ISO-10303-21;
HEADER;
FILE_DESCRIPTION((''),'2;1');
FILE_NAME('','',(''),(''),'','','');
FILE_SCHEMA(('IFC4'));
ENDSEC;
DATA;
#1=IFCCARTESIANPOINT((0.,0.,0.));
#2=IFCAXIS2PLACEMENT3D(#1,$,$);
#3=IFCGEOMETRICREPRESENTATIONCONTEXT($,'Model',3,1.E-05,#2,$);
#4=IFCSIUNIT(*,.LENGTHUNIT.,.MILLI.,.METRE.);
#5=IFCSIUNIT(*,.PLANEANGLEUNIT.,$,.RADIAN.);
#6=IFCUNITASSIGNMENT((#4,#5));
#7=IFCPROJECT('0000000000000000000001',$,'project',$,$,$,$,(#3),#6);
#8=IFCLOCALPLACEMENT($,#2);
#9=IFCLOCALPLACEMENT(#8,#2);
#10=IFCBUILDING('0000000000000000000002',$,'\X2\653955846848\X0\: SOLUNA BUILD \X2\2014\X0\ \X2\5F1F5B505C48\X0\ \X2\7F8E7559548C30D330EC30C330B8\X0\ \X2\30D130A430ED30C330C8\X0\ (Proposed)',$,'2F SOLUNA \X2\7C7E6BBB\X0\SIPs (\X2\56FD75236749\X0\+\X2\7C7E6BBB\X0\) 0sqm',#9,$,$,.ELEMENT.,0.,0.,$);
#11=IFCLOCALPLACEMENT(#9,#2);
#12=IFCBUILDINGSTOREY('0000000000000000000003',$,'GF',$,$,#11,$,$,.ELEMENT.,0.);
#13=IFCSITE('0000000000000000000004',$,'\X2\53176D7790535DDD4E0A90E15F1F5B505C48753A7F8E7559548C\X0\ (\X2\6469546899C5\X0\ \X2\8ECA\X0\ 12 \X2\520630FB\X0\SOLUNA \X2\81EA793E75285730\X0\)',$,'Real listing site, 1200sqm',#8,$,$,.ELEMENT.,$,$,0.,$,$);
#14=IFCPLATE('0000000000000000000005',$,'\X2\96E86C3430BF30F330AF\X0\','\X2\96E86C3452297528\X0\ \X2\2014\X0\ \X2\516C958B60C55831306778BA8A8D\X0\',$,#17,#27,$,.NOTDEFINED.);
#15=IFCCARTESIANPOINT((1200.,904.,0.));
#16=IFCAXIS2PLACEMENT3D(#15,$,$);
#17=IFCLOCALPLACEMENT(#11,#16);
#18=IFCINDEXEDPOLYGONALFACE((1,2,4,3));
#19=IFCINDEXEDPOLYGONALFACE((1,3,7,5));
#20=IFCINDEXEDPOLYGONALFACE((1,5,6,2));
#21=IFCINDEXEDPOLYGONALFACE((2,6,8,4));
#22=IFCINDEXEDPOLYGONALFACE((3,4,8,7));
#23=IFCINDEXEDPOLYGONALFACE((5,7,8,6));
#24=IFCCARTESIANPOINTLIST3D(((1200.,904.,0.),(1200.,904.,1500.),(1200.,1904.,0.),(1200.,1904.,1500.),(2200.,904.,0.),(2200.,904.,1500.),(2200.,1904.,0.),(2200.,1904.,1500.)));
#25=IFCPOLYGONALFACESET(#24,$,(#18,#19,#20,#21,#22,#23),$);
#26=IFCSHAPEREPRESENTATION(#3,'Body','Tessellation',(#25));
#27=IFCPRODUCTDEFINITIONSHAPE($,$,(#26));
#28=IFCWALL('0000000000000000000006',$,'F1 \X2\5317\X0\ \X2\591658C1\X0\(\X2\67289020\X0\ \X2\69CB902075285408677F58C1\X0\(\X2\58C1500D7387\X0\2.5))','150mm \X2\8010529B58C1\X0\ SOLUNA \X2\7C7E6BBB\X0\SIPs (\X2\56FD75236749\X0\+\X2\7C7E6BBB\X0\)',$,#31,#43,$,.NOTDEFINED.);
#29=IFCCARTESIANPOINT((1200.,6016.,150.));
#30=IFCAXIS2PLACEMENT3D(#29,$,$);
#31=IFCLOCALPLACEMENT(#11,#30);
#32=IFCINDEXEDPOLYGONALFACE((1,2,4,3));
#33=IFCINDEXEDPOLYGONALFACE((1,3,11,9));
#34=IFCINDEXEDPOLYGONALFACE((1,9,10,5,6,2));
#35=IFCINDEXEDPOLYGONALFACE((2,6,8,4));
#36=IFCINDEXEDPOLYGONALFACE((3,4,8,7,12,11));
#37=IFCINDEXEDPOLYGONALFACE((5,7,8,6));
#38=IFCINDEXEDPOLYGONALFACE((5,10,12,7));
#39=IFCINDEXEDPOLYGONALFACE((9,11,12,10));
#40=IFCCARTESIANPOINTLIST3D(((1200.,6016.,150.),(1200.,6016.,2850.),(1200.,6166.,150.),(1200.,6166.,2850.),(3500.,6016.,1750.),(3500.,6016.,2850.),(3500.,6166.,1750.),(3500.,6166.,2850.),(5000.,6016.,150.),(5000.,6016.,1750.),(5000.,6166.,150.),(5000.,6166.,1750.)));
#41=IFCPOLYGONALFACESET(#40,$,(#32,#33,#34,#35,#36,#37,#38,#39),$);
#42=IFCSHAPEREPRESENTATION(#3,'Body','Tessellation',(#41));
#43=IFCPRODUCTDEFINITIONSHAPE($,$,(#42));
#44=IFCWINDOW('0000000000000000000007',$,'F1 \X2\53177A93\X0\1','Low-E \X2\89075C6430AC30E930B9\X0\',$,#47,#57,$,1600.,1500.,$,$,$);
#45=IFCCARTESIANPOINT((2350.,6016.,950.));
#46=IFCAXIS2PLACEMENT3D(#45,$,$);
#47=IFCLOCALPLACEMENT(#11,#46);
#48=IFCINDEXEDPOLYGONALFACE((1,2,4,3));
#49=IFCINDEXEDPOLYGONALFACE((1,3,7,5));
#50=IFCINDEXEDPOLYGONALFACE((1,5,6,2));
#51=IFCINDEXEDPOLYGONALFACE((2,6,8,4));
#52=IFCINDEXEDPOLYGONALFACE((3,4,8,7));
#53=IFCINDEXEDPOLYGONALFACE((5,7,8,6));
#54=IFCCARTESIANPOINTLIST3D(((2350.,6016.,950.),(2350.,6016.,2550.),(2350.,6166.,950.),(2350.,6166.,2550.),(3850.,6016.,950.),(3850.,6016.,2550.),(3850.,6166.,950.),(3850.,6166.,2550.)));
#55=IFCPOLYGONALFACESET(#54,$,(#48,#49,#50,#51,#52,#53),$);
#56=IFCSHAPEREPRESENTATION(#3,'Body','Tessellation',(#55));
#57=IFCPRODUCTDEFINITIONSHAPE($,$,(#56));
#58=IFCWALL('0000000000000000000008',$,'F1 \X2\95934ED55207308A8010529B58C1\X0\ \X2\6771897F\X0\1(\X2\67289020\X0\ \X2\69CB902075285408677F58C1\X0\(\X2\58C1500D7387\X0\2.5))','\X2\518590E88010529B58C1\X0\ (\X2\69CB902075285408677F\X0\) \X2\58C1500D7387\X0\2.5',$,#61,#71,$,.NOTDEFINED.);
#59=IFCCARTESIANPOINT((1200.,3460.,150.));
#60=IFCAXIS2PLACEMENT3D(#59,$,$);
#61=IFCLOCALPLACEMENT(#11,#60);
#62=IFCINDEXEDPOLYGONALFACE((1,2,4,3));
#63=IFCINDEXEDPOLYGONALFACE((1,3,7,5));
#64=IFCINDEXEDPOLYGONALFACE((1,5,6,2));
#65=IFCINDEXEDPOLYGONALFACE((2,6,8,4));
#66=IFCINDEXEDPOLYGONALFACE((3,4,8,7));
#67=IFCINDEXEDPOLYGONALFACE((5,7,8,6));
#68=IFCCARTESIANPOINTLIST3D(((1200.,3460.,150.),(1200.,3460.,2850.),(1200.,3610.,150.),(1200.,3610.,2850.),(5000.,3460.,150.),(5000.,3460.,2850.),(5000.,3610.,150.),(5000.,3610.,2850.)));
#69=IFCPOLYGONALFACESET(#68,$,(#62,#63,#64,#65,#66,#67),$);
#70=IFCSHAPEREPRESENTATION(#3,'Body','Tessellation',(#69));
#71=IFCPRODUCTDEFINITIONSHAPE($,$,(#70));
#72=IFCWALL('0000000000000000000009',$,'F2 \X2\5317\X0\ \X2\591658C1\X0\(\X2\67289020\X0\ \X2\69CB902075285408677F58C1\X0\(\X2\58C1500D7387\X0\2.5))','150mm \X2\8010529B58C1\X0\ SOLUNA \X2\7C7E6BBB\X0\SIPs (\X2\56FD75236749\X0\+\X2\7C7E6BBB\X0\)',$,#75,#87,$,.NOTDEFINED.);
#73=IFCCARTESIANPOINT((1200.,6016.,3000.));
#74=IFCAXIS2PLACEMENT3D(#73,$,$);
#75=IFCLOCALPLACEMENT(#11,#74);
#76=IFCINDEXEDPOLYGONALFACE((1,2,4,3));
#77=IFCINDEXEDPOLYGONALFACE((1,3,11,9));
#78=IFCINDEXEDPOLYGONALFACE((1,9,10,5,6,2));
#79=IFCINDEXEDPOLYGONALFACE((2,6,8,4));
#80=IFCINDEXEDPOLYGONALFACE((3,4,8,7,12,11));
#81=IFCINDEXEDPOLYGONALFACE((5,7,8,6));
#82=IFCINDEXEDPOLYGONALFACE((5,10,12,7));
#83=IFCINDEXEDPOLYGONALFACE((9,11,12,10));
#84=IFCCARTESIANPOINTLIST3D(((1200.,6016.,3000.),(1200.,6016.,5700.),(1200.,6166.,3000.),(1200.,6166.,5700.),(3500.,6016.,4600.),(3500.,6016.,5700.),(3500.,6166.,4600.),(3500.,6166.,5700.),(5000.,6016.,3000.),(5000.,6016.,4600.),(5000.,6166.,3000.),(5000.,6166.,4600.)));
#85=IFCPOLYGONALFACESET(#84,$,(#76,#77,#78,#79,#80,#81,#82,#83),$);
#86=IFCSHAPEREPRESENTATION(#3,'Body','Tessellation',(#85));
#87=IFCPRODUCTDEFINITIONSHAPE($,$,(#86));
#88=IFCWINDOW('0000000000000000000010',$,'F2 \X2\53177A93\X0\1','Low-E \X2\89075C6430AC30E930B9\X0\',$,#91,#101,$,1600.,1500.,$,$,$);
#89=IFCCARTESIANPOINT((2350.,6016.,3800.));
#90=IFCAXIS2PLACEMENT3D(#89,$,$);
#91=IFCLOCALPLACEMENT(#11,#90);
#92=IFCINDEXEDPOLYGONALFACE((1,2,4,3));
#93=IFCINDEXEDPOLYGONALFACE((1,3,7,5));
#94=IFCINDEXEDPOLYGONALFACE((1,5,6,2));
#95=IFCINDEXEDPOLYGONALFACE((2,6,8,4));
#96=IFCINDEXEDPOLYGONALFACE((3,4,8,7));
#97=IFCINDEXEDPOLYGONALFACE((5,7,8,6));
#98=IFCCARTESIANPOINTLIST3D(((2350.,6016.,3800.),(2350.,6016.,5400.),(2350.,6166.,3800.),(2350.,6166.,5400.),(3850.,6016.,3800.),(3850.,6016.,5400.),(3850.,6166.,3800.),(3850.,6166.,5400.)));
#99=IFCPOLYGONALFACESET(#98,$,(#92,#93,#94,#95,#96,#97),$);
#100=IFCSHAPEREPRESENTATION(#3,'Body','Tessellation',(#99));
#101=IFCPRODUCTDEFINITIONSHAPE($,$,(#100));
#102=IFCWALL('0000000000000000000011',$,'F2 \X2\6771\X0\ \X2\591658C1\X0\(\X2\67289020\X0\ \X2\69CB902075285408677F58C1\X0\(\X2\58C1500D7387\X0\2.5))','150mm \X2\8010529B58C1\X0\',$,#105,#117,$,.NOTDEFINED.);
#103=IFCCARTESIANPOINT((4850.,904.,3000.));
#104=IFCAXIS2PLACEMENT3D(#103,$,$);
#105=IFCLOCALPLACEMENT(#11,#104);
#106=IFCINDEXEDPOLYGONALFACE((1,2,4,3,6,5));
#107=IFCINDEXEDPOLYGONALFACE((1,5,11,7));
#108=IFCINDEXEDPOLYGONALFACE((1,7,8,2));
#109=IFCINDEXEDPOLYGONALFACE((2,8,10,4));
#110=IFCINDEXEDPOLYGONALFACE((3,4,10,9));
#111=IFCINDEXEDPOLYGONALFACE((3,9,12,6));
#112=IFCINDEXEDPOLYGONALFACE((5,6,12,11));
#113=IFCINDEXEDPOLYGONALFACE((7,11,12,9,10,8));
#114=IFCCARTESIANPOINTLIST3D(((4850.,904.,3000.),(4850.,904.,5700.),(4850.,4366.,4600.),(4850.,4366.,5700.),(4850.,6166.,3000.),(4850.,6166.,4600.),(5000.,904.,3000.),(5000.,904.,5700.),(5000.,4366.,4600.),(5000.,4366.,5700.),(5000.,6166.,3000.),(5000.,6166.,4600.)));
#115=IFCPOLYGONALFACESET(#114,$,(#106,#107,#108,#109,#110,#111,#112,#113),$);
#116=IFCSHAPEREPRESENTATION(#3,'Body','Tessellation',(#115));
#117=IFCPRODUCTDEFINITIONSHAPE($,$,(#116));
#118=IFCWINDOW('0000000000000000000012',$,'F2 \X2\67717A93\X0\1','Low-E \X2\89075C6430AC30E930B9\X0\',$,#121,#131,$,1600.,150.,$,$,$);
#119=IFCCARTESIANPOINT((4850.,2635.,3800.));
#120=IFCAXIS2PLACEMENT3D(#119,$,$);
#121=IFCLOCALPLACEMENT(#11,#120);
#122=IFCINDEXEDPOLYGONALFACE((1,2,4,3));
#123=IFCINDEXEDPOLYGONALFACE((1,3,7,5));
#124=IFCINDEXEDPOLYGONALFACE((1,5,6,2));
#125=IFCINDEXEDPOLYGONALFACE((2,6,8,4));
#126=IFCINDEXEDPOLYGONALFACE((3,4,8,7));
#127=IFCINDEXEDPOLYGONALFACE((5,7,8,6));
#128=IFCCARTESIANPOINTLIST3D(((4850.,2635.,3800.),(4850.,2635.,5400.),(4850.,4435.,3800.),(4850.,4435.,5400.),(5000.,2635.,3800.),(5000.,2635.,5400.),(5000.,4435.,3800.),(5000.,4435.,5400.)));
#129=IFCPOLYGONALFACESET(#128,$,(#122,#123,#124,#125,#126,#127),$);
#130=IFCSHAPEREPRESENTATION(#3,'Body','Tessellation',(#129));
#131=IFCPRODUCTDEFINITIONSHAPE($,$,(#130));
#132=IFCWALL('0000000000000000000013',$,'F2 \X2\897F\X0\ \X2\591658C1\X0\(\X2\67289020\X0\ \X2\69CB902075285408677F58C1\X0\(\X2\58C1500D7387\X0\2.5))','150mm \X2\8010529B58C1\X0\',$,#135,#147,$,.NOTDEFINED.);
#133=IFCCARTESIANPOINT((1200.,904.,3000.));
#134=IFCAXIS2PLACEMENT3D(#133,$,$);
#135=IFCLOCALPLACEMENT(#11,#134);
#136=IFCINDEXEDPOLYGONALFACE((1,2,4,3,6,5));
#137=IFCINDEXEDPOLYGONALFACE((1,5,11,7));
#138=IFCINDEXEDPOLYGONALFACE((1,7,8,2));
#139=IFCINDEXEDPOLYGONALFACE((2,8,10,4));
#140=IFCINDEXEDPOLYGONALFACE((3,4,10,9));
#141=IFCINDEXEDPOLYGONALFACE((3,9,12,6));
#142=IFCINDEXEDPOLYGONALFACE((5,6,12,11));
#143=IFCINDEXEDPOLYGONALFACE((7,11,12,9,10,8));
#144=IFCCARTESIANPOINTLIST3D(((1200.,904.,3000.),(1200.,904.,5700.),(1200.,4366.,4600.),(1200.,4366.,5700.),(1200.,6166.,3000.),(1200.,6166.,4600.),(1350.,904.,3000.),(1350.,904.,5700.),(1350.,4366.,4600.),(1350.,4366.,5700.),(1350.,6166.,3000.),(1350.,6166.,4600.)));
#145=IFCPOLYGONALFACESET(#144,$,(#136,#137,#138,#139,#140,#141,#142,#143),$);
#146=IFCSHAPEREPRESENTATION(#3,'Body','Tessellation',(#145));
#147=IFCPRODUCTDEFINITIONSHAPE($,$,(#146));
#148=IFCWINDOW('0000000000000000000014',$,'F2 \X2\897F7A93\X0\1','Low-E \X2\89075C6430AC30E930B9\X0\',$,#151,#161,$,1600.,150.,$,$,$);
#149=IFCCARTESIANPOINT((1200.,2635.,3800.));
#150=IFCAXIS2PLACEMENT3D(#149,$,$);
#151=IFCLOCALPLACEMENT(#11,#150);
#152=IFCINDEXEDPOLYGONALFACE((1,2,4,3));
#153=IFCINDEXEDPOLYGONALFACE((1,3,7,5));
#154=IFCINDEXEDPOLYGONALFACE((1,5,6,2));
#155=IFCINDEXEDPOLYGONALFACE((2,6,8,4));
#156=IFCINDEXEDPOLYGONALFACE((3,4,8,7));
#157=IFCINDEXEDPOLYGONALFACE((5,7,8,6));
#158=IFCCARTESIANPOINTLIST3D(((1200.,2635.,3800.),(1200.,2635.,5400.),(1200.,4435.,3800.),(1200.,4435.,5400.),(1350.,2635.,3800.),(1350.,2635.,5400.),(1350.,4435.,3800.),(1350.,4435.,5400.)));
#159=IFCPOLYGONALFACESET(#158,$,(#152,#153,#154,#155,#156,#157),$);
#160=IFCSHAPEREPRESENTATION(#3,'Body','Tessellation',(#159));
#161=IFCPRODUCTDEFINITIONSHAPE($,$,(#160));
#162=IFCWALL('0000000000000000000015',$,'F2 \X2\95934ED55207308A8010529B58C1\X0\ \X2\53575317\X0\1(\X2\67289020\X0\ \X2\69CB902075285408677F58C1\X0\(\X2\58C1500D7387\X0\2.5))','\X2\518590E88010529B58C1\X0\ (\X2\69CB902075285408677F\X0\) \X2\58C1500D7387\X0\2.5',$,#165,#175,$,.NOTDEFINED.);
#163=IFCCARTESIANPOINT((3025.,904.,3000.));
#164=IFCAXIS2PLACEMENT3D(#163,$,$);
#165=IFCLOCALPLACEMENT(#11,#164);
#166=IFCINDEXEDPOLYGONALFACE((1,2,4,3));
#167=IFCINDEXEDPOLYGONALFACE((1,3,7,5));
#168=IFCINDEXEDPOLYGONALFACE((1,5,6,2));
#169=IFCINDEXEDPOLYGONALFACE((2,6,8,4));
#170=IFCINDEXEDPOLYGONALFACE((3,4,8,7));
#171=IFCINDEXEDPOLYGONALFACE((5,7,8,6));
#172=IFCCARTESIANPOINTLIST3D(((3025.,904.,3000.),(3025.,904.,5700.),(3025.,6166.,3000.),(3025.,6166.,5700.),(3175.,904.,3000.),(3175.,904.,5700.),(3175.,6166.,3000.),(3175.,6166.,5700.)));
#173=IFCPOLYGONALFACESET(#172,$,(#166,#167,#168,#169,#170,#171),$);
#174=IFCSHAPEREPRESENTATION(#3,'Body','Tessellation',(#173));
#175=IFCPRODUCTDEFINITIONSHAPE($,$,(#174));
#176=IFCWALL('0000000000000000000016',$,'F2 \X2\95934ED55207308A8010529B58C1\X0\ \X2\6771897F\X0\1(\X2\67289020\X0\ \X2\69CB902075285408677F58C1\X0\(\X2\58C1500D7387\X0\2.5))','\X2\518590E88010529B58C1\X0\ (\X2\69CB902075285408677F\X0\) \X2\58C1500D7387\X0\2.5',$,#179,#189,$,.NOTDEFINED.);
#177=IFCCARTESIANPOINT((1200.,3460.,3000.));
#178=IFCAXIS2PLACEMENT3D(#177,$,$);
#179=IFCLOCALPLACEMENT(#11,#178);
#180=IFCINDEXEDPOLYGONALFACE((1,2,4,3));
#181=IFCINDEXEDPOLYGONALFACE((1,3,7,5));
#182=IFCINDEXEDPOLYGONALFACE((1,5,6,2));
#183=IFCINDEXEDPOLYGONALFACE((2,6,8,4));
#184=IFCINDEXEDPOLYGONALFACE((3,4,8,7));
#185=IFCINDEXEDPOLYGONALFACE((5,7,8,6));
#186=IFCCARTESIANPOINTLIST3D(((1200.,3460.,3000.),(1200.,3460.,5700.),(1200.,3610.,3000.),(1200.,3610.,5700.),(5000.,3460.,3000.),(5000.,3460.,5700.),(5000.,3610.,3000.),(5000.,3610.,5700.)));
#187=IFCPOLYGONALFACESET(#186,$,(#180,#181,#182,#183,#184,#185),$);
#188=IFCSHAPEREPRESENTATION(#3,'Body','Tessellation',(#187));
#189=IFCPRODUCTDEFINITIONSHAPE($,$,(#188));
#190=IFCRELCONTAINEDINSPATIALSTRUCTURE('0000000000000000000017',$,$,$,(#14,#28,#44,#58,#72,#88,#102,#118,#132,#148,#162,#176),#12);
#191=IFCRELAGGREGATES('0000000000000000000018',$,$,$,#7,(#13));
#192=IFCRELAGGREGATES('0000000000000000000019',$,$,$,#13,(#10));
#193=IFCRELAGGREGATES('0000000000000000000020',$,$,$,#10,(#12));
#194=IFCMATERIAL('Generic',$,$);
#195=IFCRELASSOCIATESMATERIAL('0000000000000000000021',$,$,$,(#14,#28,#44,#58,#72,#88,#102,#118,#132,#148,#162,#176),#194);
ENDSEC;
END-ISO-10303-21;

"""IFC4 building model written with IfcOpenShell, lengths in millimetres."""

from ifc_helpers import new_model, si_unit, frame, frame_2d, origin, place, context, project, spatial, rectangle, extrude, material, element, fill, save


model = new_model("IFC4")

# Units and contexts
model_context = context("Model", 3, precision=1e-05, world=origin())
ifc_project = project(units=[si_unit("LENGTHUNIT", "METRE", prefix="MILLI"), si_unit("PLANEANGLEUNIT", "RADIAN")], contexts=[model_context])

# Site, building, storey
site_placement = place(None, origin())
site = spatial("IfcSite", under=ifc_project, at=site_placement, Name="北海道川上郡弟子屈町美留和 (摩周駅 車 12 分・SOLUNA 自社用地)", ObjectType="Real listing site, 1200sqm", CompositionType="ELEMENT", RefElevation=0.0)
building_placement = place(site_placement, origin())
building = spatial("IfcBuilding", under=site, at=building_placement, Name="改善案: SOLUNA BUILD — 弟子屈 美留和ビレッジ パイロット (Proposed)", ObjectType="2F SOLUNA 籾殻SIPs (国産杉+籾殻) 0sqm", CompositionType="ELEMENT", ElevationOfRefHeight=0.0, ElevationOfTerrain=0.0)
storey_placement = place(building_placement, origin())
storey = spatial("IfcBuildingStorey", under=building, at=storey_placement, Name="GF", CompositionType="ELEMENT", Elevation=0.0)

# Plate
ifc_material_1 = material(Name="Generic")
plate_placement = place(storey_placement, frame((1200.0, 904.0, 0.0)))
element("IfcPlate", 1, at=plate_placement, inside=storey, material=ifc_material_1, Name="雨水タンク", Description="雨水利用 — 公開情報で確認", PredefinedType="NOTDEFINED", context=model_context, shape_type="SweptSolid", body=[
    extrude(rectangle(XDim=1000.0, YDim=1000.0, at=frame_2d((500.0, 500.0))), frame((1200.0, 904.0, 0.0)), (0.0, 0.0, 1.0), 1500.0),
])

# Wall, opening, window
wall_1_placement = place(storey_placement, frame((1200.0, 6016.0, 150.0)))
wall_1 = element("IfcWall", 2, at=wall_1_placement, inside=storey, material=ifc_material_1, Name="F1 北 外壁(木造 構造用合板壁(壁倍率2.5))", Description="150mm 耐力壁 SOLUNA 籾殻SIPs (国産杉+籾殻)", PredefinedType="NOTDEFINED", context=model_context, shape_type="SweptSolid", body=[
    extrude(rectangle(XDim=3800.0, YDim=150.0, at=frame_2d((1900.0, 75.0))), frame((1200.0, 6016.0, 150.0)), (0.0, 0.0, 1.0), 2700.0),
])
opening_1_placement = place(storey_placement, frame((2350.0, 6016.0, 950.0)))
opening_1 = element("IfcOpeningElement", 3, at=opening_1_placement, cuts=wall_1, PredefinedType="NOTDEFINED", context=model_context, shape_type="SweptSolid", body=[
    extrude(rectangle(XDim=1500.0, YDim=150.0, at=frame_2d((750.0, 75.0))), frame((2350.0, 6016.0, 950.0)), (0.0, 0.0, 1.0), 1600.0),
])
window_1_placement = place(storey_placement, frame((2350.0, 6016.0, 950.0)))
window_1 = element("IfcWindow", 4, at=window_1_placement, inside=storey, material=ifc_material_1, Name="F1 北窓1", Description="Low-E 複層ガラス", OverallHeight=1600.0, OverallWidth=1500.0, context=model_context, shape_type="SweptSolid", body=[
    extrude(rectangle(XDim=1500.0, YDim=150.0, at=frame_2d((750.0, 75.0))), frame((2350.0, 6016.0, 950.0)), (0.0, 0.0, 1.0), 1600.0),
])
fill(opening_1, window_1)

# Wall
wall_2_placement = place(storey_placement, frame((1200.0, 3460.0, 150.0)))
element("IfcWall", 5, at=wall_2_placement, inside=storey, material=ifc_material_1, Name="F1 間仕切り耐力壁 東西1(木造 構造用合板壁(壁倍率2.5))", Description="内部耐力壁 (構造用合板) 壁倍率2.5", PredefinedType="NOTDEFINED", context=model_context, shape_type="SweptSolid", body=[
    extrude(rectangle(XDim=3800.0, YDim=150.0, at=frame_2d((1900.0, 75.0))), frame((1200.0, 3460.0, 150.0)), (0.0, 0.0, 1.0), 2700.0),
])

# Walls, openings, windows
wall_3_placement = place(storey_placement, frame((1200.0, 6016.0, 3000.0)))
wall_3 = element("IfcWall", 6, at=wall_3_placement, inside=storey, material=ifc_material_1, Name="F2 北 外壁(木造 構造用合板壁(壁倍率2.5))", Description="150mm 耐力壁 SOLUNA 籾殻SIPs (国産杉+籾殻)", PredefinedType="NOTDEFINED", context=model_context, shape_type="SweptSolid", body=[
    extrude(rectangle(XDim=3800.0, YDim=150.0, at=frame_2d((1900.0, 75.0))), frame((1200.0, 6016.0, 3000.0)), (0.0, 0.0, 1.0), 2700.0),
])
opening_2_placement = place(storey_placement, frame((2350.0, 6016.0, 3800.0)))
opening_2 = element("IfcOpeningElement", 7, at=opening_2_placement, cuts=wall_3, PredefinedType="NOTDEFINED", context=model_context, shape_type="SweptSolid", body=[
    extrude(rectangle(XDim=1500.0, YDim=150.0, at=frame_2d((750.0, 75.0))), frame((2350.0, 6016.0, 3800.0)), (0.0, 0.0, 1.0), 1600.0),
])
window_2_placement = place(storey_placement, frame((2350.0, 6016.0, 3800.0)))
window_2 = element("IfcWindow", 8, at=window_2_placement, inside=storey, material=ifc_material_1, Name="F2 北窓1", Description="Low-E 複層ガラス", OverallHeight=1600.0, OverallWidth=1500.0, context=model_context, shape_type="SweptSolid", body=[
    extrude(rectangle(XDim=1500.0, YDim=150.0, at=frame_2d((750.0, 75.0))), frame((2350.0, 6016.0, 3800.0)), (0.0, 0.0, 1.0), 1600.0),
])
fill(opening_2, window_2)
wall_4_placement = place(storey_placement, frame((4850.0, 904.0, 3000.0)))
wall_4 = element("IfcWall", 9, at=wall_4_placement, inside=storey, material=ifc_material_1, Name="F2 東 外壁(木造 構造用合板壁(壁倍率2.5))", Description="150mm 耐力壁", PredefinedType="NOTDEFINED", context=model_context, shape_type="SweptSolid", body=[
    extrude(rectangle(XDim=150.0, YDim=5262.0, at=frame_2d((75.0, 2631.0))), frame((4850.0, 904.0, 3000.0)), (0.0, 0.0, 1.0), 2700.0),
])
opening_3_placement = place(storey_placement, frame((4850.0, 2635.0, 3800.0)))
opening_3 = element("IfcOpeningElement", 10, at=opening_3_placement, cuts=wall_4, PredefinedType="NOTDEFINED", context=model_context, shape_type="SweptSolid", body=[
    extrude(rectangle(XDim=150.0, YDim=1800.0, at=frame_2d((75.0, 900.0))), frame((4850.0, 2635.0, 3800.0)), (0.0, 0.0, 1.0), 1600.0),
])
window_3_placement = place(storey_placement, frame((4850.0, 2635.0, 3800.0)))
window_3 = element("IfcWindow", 11, at=window_3_placement, inside=storey, material=ifc_material_1, Name="F2 東窓1", Description="Low-E 複層ガラス", OverallHeight=1600.0, OverallWidth=150.0, context=model_context, shape_type="SweptSolid", body=[
    extrude(rectangle(XDim=150.0, YDim=1800.0, at=frame_2d((75.0, 900.0))), frame((4850.0, 2635.0, 3800.0)), (0.0, 0.0, 1.0), 1600.0),
])
fill(opening_3, window_3)
wall_5_placement = place(storey_placement, frame((1200.0, 904.0, 3000.0)))
wall_5 = element("IfcWall", 12, at=wall_5_placement, inside=storey, material=ifc_material_1, Name="F2 西 外壁(木造 構造用合板壁(壁倍率2.5))", Description="150mm 耐力壁", PredefinedType="NOTDEFINED", context=model_context, shape_type="SweptSolid", body=[
    extrude(rectangle(XDim=150.0, YDim=5262.0, at=frame_2d((75.0, 2631.0))), frame((1200.0, 904.0, 3000.0)), (0.0, 0.0, 1.0), 2700.0),
])
opening_4_placement = place(storey_placement, frame((1200.0, 2635.0, 3800.0)))
opening_4 = element("IfcOpeningElement", 13, at=opening_4_placement, cuts=wall_5, PredefinedType="NOTDEFINED", context=model_context, shape_type="SweptSolid", body=[
    extrude(rectangle(XDim=150.0, YDim=1800.0, at=frame_2d((75.0, 900.0))), frame((1200.0, 2635.0, 3800.0)), (0.0, 0.0, 1.0), 1600.0),
])
window_4_placement = place(storey_placement, frame((1200.0, 2635.0, 3800.0)))
window_4 = element("IfcWindow", 14, at=window_4_placement, inside=storey, material=ifc_material_1, Name="F2 西窓1", Description="Low-E 複層ガラス", OverallHeight=1600.0, OverallWidth=150.0, context=model_context, shape_type="SweptSolid", body=[
    extrude(rectangle(XDim=150.0, YDim=1800.0, at=frame_2d((75.0, 900.0))), frame((1200.0, 2635.0, 3800.0)), (0.0, 0.0, 1.0), 1600.0),
])
fill(opening_4, window_4)

# Walls
wall_6_placement = place(storey_placement, frame((3025.0, 904.0, 3000.0)))
element("IfcWall", 15, at=wall_6_placement, inside=storey, material=ifc_material_1, Name="F2 間仕切り耐力壁 南北1(木造 構造用合板壁(壁倍率2.5))", Description="内部耐力壁 (構造用合板) 壁倍率2.5", PredefinedType="NOTDEFINED", context=model_context, shape_type="SweptSolid", body=[
    extrude(rectangle(XDim=150.0, YDim=5262.0, at=frame_2d((75.0, 2631.0))), frame((3025.0, 904.0, 3000.0)), (0.0, 0.0, 1.0), 2700.0),
])
wall_7_placement = place(storey_placement, frame((1200.0, 3460.0, 3000.0)))
element("IfcWall", 16, at=wall_7_placement, inside=storey, material=ifc_material_1, Name="F2 間仕切り耐力壁 東西1(木造 構造用合板壁(壁倍率2.5))", Description="内部耐力壁 (構造用合板) 壁倍率2.5", PredefinedType="NOTDEFINED", context=model_context, shape_type="SweptSolid", body=[
    extrude(rectangle(XDim=3800.0, YDim=150.0, at=frame_2d((1900.0, 75.0))), frame((1200.0, 3460.0, 3000.0)), (0.0, 0.0, 1.0), 2700.0),
])

save(model, "model.ifc")
